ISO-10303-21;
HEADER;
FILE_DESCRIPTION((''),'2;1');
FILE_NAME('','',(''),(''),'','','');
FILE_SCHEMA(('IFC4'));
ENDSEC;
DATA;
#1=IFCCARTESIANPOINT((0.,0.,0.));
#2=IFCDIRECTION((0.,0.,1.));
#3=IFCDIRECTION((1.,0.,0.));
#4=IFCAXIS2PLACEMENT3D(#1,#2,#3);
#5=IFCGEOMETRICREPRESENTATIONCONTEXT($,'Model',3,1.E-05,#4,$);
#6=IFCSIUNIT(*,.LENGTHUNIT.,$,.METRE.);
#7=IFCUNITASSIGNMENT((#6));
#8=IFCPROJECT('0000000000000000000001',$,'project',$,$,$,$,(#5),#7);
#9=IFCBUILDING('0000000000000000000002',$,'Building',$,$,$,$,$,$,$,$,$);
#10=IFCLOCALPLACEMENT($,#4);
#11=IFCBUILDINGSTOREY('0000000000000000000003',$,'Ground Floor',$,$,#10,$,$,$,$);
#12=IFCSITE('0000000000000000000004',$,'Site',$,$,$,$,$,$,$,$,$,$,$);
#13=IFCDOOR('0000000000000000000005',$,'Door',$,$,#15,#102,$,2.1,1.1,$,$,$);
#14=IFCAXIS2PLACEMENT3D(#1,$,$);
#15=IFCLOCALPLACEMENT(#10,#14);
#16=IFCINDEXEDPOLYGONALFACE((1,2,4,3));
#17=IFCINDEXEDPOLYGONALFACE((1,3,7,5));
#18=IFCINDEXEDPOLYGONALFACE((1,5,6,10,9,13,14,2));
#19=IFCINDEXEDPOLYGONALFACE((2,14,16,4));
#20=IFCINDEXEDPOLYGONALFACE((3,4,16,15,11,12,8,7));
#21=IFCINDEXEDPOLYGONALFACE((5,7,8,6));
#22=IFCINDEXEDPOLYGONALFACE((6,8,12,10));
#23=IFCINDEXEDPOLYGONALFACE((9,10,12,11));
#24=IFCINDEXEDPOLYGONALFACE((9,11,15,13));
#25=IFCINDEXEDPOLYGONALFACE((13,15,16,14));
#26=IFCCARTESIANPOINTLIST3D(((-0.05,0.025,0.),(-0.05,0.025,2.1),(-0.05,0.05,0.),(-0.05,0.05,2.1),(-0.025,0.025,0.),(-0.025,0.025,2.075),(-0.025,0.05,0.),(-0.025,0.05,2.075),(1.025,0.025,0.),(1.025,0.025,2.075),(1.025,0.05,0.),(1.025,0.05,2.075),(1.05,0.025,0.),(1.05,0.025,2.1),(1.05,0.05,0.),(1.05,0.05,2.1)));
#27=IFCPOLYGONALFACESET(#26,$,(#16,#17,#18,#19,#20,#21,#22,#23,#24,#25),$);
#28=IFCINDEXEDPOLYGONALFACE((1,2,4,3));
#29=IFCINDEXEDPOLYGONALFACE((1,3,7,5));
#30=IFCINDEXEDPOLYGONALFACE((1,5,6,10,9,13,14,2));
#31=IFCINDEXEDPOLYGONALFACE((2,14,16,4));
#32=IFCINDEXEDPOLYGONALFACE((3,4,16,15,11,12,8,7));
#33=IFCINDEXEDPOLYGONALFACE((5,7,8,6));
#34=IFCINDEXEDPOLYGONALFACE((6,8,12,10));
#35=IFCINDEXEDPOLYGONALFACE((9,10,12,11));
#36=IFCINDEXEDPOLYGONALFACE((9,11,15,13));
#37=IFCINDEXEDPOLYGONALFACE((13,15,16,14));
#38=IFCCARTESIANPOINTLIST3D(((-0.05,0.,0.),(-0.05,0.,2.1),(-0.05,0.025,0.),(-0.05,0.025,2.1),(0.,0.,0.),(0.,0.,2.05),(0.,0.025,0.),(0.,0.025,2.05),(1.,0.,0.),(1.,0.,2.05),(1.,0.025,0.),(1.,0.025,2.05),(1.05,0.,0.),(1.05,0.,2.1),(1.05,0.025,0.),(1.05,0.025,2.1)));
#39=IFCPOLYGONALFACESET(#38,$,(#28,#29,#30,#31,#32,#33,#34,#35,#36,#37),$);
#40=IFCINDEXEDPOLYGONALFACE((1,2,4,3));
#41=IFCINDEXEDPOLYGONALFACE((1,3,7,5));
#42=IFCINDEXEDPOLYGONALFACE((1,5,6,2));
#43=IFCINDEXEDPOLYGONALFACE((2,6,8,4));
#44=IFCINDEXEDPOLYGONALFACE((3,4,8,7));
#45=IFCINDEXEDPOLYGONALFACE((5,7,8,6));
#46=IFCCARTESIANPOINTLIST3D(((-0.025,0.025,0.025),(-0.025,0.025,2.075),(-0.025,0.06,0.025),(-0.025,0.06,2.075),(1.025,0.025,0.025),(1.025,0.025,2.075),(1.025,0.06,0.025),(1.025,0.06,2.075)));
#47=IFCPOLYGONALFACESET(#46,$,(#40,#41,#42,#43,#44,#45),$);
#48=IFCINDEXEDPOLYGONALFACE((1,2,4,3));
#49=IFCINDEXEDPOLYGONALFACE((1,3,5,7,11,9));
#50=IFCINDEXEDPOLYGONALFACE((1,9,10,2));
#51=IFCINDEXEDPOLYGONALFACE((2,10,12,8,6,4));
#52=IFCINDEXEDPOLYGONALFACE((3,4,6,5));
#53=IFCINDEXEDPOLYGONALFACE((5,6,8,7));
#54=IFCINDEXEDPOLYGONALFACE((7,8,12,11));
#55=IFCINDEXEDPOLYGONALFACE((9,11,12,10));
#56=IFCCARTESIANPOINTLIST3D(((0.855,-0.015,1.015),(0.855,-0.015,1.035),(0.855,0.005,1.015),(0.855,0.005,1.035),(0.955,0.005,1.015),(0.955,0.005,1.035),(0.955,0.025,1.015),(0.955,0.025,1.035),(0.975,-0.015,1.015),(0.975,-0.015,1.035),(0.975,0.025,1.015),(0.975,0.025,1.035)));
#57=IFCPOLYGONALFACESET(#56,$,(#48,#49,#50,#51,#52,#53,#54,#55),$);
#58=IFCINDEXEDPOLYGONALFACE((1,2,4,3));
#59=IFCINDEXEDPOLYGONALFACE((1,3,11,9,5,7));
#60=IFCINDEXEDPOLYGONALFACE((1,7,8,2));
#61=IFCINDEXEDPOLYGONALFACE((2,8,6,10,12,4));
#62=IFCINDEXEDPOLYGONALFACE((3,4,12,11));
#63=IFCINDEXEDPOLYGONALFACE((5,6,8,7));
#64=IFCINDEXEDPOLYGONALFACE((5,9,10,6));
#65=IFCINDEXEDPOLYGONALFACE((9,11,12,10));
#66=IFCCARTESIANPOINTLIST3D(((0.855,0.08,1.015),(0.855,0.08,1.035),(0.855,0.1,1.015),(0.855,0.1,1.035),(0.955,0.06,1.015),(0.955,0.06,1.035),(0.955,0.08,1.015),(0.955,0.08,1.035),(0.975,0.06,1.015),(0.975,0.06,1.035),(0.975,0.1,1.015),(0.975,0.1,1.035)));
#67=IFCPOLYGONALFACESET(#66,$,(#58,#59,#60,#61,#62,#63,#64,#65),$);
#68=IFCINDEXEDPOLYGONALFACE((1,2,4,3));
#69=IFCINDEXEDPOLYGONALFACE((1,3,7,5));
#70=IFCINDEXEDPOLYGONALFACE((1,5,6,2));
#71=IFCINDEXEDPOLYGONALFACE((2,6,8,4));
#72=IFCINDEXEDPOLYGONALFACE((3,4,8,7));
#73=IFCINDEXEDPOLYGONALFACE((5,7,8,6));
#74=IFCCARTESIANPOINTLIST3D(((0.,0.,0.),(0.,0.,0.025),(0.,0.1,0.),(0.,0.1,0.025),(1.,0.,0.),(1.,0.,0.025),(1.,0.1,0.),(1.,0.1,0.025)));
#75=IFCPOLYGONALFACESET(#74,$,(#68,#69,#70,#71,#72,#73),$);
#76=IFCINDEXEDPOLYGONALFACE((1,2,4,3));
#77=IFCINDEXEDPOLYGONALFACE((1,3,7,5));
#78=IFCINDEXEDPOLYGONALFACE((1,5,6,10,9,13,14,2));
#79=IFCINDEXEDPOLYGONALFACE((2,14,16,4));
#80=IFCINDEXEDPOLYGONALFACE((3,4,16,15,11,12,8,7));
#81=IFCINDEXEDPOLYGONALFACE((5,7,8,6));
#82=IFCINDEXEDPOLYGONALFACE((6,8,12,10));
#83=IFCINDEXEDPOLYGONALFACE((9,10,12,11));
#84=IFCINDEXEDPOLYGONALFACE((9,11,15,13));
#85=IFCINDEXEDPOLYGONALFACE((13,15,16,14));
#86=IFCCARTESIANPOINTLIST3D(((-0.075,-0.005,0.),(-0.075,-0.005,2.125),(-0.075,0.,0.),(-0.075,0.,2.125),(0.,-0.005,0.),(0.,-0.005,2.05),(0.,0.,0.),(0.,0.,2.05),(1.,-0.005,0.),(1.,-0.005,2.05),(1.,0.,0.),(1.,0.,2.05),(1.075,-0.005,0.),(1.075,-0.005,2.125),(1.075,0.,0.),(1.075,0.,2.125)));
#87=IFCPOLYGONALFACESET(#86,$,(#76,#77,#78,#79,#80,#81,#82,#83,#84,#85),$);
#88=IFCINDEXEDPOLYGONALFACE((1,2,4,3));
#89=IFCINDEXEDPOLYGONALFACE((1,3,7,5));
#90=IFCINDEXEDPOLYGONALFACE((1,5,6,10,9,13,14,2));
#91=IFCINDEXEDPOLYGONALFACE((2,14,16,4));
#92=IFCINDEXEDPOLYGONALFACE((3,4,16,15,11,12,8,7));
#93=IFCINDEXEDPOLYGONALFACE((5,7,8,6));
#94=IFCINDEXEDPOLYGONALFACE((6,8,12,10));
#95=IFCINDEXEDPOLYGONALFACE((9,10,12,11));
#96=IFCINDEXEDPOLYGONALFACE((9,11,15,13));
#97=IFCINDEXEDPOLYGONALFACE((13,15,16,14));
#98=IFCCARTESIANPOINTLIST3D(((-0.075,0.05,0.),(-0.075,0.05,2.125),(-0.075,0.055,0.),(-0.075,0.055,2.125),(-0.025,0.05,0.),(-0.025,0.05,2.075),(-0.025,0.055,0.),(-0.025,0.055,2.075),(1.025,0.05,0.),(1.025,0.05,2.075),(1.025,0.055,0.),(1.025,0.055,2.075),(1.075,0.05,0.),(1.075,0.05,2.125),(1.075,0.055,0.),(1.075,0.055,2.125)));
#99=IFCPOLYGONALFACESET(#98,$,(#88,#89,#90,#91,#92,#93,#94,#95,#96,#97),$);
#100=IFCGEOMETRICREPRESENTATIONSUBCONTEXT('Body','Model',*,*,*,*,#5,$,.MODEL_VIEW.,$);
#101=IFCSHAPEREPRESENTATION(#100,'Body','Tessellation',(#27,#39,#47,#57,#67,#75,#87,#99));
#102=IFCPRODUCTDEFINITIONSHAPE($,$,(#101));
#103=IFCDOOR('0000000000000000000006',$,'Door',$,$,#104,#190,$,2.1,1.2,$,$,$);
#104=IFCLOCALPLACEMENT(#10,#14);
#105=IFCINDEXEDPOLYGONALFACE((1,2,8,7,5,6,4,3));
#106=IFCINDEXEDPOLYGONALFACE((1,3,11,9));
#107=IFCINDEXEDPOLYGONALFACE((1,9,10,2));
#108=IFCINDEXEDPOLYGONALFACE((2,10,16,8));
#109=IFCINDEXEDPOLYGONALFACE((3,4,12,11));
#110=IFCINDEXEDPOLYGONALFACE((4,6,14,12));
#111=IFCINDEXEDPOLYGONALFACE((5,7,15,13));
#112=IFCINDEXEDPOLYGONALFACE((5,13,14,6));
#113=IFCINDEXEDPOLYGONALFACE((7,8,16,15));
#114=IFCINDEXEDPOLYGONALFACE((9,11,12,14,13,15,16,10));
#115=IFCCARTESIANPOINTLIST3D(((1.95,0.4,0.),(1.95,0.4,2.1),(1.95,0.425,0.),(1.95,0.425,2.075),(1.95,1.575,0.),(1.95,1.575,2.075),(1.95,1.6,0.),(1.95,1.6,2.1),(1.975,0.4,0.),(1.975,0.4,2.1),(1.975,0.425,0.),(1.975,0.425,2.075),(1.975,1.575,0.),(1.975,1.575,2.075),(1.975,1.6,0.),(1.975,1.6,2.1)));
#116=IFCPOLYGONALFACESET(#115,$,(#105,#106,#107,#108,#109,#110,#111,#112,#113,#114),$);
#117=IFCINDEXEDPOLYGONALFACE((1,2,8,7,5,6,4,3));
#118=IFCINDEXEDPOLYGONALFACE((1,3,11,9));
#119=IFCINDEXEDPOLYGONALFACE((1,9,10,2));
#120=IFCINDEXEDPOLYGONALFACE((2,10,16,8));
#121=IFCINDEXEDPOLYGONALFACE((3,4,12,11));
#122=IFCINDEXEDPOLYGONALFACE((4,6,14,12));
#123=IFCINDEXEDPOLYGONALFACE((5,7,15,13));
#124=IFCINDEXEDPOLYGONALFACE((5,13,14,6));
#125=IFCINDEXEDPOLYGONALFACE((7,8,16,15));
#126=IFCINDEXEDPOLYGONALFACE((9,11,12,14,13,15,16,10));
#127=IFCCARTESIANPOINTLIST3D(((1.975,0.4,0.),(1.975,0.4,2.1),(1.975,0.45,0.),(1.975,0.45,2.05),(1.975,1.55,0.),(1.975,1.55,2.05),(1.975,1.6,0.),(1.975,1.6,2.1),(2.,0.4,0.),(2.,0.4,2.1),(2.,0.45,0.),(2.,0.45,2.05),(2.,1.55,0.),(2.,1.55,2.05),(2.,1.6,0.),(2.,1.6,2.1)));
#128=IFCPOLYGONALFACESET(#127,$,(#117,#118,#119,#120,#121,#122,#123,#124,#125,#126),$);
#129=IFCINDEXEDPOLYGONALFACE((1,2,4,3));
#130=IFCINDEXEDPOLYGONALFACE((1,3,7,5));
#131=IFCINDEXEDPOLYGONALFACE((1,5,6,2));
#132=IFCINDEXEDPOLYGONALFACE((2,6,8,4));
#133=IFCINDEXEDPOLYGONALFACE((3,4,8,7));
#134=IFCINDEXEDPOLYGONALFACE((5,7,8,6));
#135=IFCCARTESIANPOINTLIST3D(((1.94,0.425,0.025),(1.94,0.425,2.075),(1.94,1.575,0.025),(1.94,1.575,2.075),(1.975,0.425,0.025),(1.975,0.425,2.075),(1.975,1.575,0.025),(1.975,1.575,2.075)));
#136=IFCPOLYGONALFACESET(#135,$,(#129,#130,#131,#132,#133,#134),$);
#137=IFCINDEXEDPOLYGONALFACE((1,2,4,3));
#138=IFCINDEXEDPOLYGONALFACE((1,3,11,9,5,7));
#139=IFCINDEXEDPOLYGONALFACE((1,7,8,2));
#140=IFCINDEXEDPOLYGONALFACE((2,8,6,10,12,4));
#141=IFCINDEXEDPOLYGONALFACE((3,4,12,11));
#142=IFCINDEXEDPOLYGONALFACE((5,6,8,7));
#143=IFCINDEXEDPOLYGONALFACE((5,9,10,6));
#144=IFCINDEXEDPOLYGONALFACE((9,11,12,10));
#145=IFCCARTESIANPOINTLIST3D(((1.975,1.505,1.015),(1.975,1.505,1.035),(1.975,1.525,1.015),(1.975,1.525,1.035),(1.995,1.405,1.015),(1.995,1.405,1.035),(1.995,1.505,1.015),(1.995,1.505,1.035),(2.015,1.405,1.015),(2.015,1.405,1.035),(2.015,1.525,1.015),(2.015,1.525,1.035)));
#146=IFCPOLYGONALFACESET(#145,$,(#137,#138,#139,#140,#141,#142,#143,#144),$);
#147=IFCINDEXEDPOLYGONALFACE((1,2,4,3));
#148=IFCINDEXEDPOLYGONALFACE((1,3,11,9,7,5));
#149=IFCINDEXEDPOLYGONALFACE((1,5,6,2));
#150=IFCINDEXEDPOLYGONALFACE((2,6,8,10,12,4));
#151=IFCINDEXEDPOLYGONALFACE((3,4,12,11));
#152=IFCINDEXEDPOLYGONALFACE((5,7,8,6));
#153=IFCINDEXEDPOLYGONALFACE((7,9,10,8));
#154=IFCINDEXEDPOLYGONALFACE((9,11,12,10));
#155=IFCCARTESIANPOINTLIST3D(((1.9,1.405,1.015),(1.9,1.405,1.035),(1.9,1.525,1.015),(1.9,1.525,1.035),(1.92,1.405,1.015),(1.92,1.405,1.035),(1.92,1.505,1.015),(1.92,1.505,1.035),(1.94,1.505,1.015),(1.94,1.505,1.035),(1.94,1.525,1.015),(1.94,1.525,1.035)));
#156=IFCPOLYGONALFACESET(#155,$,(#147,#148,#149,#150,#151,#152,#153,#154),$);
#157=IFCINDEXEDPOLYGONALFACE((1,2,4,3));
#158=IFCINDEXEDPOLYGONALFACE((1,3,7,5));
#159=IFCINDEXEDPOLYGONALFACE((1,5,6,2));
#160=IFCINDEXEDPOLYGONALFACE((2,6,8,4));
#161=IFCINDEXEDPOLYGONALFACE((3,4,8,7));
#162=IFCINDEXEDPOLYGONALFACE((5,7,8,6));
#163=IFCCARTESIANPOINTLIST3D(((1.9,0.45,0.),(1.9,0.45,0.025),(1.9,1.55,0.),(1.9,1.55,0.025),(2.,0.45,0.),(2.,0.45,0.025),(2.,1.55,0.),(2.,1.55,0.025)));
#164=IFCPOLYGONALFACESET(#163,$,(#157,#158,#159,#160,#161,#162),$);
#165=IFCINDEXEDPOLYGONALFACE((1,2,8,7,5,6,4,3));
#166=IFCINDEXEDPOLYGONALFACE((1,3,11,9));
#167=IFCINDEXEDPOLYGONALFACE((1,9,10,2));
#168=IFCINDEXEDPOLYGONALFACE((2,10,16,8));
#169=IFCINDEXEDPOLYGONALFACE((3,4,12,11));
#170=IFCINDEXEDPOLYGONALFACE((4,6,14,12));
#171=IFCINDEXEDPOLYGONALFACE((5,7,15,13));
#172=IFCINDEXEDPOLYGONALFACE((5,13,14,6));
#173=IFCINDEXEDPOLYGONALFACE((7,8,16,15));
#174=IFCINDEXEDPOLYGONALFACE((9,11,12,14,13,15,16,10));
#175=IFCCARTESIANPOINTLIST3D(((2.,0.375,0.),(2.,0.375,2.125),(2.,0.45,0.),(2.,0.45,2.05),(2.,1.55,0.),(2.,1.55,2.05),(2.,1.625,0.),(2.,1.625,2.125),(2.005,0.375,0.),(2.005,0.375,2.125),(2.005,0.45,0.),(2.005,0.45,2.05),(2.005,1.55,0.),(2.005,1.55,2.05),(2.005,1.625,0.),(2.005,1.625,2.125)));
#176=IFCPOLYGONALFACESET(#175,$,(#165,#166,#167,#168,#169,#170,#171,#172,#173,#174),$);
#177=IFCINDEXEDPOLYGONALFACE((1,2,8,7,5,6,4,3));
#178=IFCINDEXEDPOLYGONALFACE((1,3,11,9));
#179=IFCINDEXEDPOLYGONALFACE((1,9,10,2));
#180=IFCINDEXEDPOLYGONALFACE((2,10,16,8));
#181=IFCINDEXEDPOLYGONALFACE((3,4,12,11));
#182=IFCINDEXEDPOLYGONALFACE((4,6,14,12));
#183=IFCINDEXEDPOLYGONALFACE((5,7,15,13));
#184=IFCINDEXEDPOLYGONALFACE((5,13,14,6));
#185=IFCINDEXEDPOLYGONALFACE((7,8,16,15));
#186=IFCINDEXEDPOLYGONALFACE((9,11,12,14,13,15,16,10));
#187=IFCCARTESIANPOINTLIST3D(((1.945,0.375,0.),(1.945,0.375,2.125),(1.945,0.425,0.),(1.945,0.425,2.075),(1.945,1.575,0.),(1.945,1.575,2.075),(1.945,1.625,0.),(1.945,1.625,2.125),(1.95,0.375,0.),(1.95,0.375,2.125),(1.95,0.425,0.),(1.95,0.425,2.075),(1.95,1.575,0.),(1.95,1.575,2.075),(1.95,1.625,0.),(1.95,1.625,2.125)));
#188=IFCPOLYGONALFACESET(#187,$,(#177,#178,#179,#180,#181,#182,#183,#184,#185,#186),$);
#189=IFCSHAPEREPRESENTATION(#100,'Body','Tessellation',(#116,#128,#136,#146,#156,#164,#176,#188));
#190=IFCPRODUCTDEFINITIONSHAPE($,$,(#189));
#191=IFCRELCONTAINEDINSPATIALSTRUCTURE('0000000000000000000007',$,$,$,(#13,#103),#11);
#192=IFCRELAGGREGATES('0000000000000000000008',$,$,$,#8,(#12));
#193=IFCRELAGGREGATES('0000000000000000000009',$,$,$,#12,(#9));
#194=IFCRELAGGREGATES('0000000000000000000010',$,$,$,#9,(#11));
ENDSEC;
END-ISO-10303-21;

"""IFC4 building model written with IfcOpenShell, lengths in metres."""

from ifc_helpers import new_model, si_unit, frame, origin_with_axes, place, context, subcontext, project, spatial, line, indexed_curve, outline, extrude, element, save


model = new_model("IFC4")

# Units and contexts
model_context = context("Model", 3, precision=1e-05, world=origin_with_axes())
body_context = subcontext(model_context, "Body", "Model", "MODEL_VIEW")
ifc_project = project(units=[si_unit("LENGTHUNIT", "METRE")], contexts=[model_context])

# Site, building, storey
site = spatial("IfcSite", under=ifc_project, Name="Site")
building = spatial("IfcBuilding", under=site, Name="Building")
storey_placement = place(None, origin_with_axes())
storey = spatial("IfcBuildingStorey", under=building, at=storey_placement, Name="Ground Floor")

# Doors
door_1_placement = place(storey_placement, frame((-0.05, 0.0, 0.0), z_axis=(0.0, 0.0, 1.0), x_axis=(1.0, 0.0, 0.0)))
element("IfcDoor", 1, at=door_1_placement, inside=storey, Name="Door", OverallHeight=2.1, OverallWidth=1.1, context=body_context, shape_type="SweptSolid", body=[
    extrude(outline(indexed_curve([(0.0, 0.0), (0.0, 2.1), (1.1, 2.1), (1.1, 0.0), (1.075, 0.0), (1.075, 2.075), (0.025, 2.075), (0.025, 0.0)], segments=[line(1, 2, 3, 4, 5, 6, 7, 8, 1)])), frame((0.0, 0.025, 0.0), z_axis=(0.0, -1.0, 0.0), x_axis=(1.0, 0.0, 0.0)), (0.0, 0.0, -1.0), 0.025),
    extrude(outline(indexed_curve([(0.0, 0.0), (0.0, 2.1), (1.1, 2.1), (1.1, 0.0), (1.05, 0.0), (1.05, 2.05), (0.05, 2.05), (0.05, 0.0)], segments=[line(1, 2, 3, 4, 5, 6, 7, 8, 1)])), frame((0.0, 0.0, 0.0), z_axis=(0.0, -1.0, 0.0), x_axis=(1.0, 0.0, 0.0)), (0.0, 0.0, -1.0), 0.025),
    extrude(outline(indexed_curve([(0.0, 0.0), (1.05, 0.0), (1.05, 0.035), (0.0, 0.035)], segments=[line(1, 2, 3, 4, 1)])), frame((0.025, 0.025, 0.025), z_axis=(0.0, 0.0, 1.0), x_axis=(1.0, 0.0, 0.0)), (0.0, 0.0, 1.0), 2.05),
    extrude(outline(indexed_curve([(0.0, 0.0), (0.0, -0.04), (-0.12, -0.04), (-0.12, -0.02), (-0.02, -0.02), (-0.02, 0.0)], segments=[line(1, 2, 3, 4, 5, 6, 1)])), frame((1.025, 0.025, 1.015), z_axis=(0.0, 0.0, 1.0), x_axis=(1.0, 0.0, 0.0)), (0.0, 0.0, 1.0), 0.02),
    extrude(outline(indexed_curve([(0.0, 0.0), (0.0, 0.04), (-0.12, 0.04), (-0.12, 0.02), (-0.02, 0.02), (-0.02, 0.0)], segments=[line(1, 2, 3, 4, 5, 6, 1)])), frame((1.025, 0.06, 1.015), z_axis=(0.0, 0.0, 1.0), x_axis=(1.0, 0.0, 0.0)), (0.0, 0.0, 1.0), 0.02),
    extrude(outline(indexed_curve([(0.0, 0.0), (1.0, 0.0), (1.0, 0.1), (0.0, 0.1)], segments=[line(1, 2, 3, 4, 1)])), frame((0.05, 0.0, 0.0), z_axis=(0.0, 0.0, 1.0), x_axis=(1.0, 0.0, 0.0)), (0.0, 0.0, 1.0), 0.025),
    extrude(outline(indexed_curve([(0.0, 0.0), (0.0, 2.125), (1.15, 2.125), (1.15, 0.0), (1.075, 0.0), (1.075, 2.05), (0.075, 2.05), (0.075, 0.0)], segments=[line(1, 2, 3, 4, 5, 6, 7, 8, 1)])), frame((-0.025, -0.005, 0.0), z_axis=(0.0, -1.0, 0.0), x_axis=(1.0, 0.0, 0.0)), (0.0, 0.0, -1.0), 0.005),
    extrude(outline(indexed_curve([(0.0, 0.0), (0.0, 2.125), (1.15, 2.125), (1.15, 0.0), (1.1, 0.0), (1.1, 2.075), (0.05, 2.075), (0.05, 0.0)], segments=[line(1, 2, 3, 4, 5, 6, 7, 8, 1)])), frame((-0.025, 0.05, 0.0), z_axis=(0.0, -1.0, 0.0), x_axis=(1.0, 0.0, 0.0)), (0.0, 0.0, -1.0), 0.005),
])
door_2_placement = place(storey_placement, frame((2.0, 0.4, 0.0), z_axis=(0.0, 0.0, 1.0), x_axis=(0.0, 1.0, 0.0)))
element("IfcDoor", 2, at=door_2_placement, inside=storey, Name="Door", OverallHeight=2.1, OverallWidth=1.2, context=body_context, shape_type="SweptSolid", body=[
    extrude(outline(indexed_curve([(0.0, 0.0), (0.0, 2.1), (1.2, 2.1), (1.2, 0.0), (1.175, 0.0), (1.175, 2.075), (0.025, 2.075), (0.025, 0.0)], segments=[line(1, 2, 3, 4, 5, 6, 7, 8, 1)])), frame((0.0, 0.025, 0.0), z_axis=(0.0, -1.0, 0.0), x_axis=(1.0, 0.0, 0.0)), (0.0, 0.0, -1.0), 0.025),
    extrude(outline(indexed_curve([(0.0, 0.0), (0.0, 2.1), (1.2, 2.1), (1.2, 0.0), (1.15, 0.0), (1.15, 2.05), (0.05, 2.05), (0.05, 0.0)], segments=[line(1, 2, 3, 4, 5, 6, 7, 8, 1)])), frame((0.0, 0.0, 0.0), z_axis=(0.0, -1.0, 0.0), x_axis=(1.0, 0.0, 0.0)), (0.0, 0.0, -1.0), 0.025),
    extrude(outline(indexed_curve([(0.0, 0.0), (1.15, 0.0), (1.15, 0.035), (0.0, 0.035)], segments=[line(1, 2, 3, 4, 1)])), frame((0.025, 0.025, 0.025), z_axis=(0.0, 0.0, 1.0), x_axis=(1.0, 0.0, 0.0)), (0.0, 0.0, 1.0), 2.05),
    extrude(outline(indexed_curve([(0.0, 0.0), (0.0, -0.04), (-0.12, -0.04), (-0.12, -0.02), (-0.02, -0.02), (-0.02, 0.0)], segments=[line(1, 2, 3, 4, 5, 6, 1)])), frame((1.125, 0.025, 1.015), z_axis=(0.0, 0.0, 1.0), x_axis=(1.0, 0.0, 0.0)), (0.0, 0.0, 1.0), 0.02),
    extrude(outline(indexed_curve([(0.0, 0.0), (0.0, 0.04), (-0.12, 0.04), (-0.12, 0.02), (-0.02, 0.02), (-0.02, 0.0)], segments=[line(1, 2, 3, 4, 5, 6, 1)])), frame((1.125, 0.06, 1.015), z_axis=(0.0, 0.0, 1.0), x_axis=(1.0, 0.0, 0.0)), (0.0, 0.0, 1.0), 0.02),
    extrude(outline(indexed_curve([(0.0, 0.0), (1.1, 0.0), (1.1, 0.1), (0.0, 0.1)], segments=[line(1, 2, 3, 4, 1)])), frame((0.05, 0.0, 0.0), z_axis=(0.0, 0.0, 1.0), x_axis=(1.0, 0.0, 0.0)), (0.0, 0.0, 1.0), 0.025),
    extrude(outline(indexed_curve([(0.0, 0.0), (0.0, 2.125), (1.25, 2.125), (1.25, 0.0), (1.175, 0.0), (1.175, 2.05), (0.075, 2.05), (0.075, 0.0)], segments=[line(1, 2, 3, 4, 5, 6, 7, 8, 1)])), frame((-0.025, -0.005, 0.0), z_axis=(0.0, -1.0, 0.0), x_axis=(1.0, 0.0, 0.0)), (0.0, 0.0, -1.0), 0.005),
    extrude(outline(indexed_curve([(0.0, 0.0), (0.0, 2.125), (1.25, 2.125), (1.25, 0.0), (1.2, 0.0), (1.2, 2.075), (0.05, 2.075), (0.05, 0.0)], segments=[line(1, 2, 3, 4, 5, 6, 7, 8, 1)])), frame((-0.025, 0.05, 0.0), z_axis=(0.0, -1.0, 0.0), x_axis=(1.0, 0.0, 0.0)), (0.0, 0.0, -1.0), 0.005),
])

save(model, "model.ifc")
